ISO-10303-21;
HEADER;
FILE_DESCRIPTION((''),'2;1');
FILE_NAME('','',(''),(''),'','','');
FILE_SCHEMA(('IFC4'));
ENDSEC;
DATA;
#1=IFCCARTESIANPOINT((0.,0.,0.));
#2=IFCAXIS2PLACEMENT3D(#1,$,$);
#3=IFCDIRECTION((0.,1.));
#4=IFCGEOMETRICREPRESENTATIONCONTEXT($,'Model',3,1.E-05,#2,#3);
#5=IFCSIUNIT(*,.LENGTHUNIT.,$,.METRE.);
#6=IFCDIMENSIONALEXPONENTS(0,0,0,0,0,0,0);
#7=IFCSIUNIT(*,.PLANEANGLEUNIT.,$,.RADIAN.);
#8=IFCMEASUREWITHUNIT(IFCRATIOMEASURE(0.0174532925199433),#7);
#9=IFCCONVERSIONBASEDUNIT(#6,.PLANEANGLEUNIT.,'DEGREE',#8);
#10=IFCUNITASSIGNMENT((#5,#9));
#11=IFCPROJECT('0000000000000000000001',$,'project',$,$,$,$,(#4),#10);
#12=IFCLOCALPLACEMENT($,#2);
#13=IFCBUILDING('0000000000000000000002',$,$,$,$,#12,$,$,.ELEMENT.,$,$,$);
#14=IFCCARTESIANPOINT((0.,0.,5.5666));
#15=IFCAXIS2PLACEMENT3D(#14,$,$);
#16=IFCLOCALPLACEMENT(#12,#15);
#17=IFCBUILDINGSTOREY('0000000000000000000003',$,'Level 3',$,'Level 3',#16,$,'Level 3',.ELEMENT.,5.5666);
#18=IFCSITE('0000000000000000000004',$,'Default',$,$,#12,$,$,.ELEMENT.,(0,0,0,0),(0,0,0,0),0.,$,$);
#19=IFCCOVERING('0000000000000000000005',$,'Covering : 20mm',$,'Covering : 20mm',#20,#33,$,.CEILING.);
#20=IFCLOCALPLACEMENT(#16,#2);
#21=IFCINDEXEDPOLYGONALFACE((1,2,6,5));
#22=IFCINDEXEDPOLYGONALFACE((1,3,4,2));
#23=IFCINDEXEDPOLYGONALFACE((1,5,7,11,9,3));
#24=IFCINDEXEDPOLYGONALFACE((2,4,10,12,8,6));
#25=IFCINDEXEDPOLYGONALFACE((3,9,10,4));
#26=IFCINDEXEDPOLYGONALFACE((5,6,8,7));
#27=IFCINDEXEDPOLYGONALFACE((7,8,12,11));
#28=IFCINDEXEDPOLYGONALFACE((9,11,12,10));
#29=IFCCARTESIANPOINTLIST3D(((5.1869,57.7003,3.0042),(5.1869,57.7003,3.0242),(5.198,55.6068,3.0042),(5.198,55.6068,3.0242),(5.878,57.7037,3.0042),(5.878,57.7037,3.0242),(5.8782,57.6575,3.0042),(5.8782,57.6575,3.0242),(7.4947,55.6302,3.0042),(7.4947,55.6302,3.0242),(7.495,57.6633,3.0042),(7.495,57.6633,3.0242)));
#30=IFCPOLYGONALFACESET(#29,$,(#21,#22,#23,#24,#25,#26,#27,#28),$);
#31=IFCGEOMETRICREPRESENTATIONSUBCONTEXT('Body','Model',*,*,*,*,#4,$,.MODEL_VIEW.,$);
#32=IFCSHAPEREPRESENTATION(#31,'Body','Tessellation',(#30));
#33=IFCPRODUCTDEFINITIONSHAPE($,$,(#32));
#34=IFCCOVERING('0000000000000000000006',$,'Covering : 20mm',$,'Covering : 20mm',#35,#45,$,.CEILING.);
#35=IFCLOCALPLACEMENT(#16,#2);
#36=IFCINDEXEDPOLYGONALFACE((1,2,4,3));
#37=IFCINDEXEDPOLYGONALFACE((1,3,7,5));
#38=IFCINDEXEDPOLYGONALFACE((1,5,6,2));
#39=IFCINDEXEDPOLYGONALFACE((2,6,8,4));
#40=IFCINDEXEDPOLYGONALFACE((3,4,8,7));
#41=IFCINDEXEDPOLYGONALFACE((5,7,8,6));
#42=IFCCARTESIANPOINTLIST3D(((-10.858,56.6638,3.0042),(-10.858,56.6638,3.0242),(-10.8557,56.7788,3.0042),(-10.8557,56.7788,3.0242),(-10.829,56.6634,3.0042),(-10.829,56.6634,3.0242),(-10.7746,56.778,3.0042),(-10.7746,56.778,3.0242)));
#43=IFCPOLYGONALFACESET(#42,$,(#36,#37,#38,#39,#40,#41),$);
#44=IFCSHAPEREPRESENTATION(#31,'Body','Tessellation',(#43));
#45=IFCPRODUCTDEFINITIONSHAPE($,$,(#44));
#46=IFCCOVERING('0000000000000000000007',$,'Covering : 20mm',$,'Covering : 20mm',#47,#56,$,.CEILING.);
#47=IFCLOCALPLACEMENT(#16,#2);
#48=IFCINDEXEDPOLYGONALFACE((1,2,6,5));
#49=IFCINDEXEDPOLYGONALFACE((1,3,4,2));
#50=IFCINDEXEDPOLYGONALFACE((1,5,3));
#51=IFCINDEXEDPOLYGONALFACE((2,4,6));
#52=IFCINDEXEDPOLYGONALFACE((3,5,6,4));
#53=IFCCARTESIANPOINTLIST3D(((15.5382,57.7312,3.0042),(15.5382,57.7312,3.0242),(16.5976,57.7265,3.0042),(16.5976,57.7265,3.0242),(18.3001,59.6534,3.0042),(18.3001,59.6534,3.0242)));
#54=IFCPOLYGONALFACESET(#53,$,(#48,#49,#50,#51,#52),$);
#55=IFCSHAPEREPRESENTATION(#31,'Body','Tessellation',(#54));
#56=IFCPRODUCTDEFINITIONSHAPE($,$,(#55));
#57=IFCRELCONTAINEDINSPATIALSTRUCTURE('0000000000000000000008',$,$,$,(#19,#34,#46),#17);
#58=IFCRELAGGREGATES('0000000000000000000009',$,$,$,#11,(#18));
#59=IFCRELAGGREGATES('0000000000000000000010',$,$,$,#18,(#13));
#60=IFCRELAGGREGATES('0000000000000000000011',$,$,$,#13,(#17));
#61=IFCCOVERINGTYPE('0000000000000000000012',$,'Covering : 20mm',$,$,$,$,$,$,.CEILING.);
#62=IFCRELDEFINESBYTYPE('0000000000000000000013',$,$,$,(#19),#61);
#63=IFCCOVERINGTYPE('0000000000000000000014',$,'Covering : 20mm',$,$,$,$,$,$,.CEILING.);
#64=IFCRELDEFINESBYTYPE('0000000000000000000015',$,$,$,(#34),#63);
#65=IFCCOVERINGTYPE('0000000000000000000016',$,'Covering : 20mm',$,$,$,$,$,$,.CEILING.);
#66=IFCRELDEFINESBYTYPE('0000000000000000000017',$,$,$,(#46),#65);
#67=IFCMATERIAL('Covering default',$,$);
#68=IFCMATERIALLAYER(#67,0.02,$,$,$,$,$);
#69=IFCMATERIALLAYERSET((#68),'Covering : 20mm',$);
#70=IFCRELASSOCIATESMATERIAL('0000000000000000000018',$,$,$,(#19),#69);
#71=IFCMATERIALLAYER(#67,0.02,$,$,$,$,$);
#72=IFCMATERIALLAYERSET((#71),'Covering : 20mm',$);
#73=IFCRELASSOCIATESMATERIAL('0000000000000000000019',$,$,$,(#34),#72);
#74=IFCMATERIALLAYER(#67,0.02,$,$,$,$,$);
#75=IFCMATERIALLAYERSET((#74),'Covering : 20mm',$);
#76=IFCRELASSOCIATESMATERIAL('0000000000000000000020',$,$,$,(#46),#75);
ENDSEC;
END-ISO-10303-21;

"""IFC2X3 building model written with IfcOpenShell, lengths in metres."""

from ifc_helpers import new_model, entity, si_unit, converted_unit, direction, frame, origin, origin_with_axes, place, context, subcontext, project, spatial, polyline, outline, extrude, material, layer, layer_set, layer_usage, type_object, element, save


model = new_model("IFC2X3")

# Units and contexts
model_context = context("Model", 3, precision=1e-05, world=origin(), true_north=direction((0.0, 1.0)))
body_context = subcontext(model_context, "Body", "Model", "MODEL_VIEW")
ifc_project = project(units=[si_unit("LENGTHUNIT", "METRE"), converted_unit("PLANEANGLEUNIT", "DEGREE", entity("IfcRatioMeasure", 0.0174532925199433), si_unit("PLANEANGLEUNIT", "RADIAN"), dimensions=[0, 0, 0, 0, 0, 0, 0])], contexts=[model_context])

# Site, building, storey
placement = place(None, origin())
site = spatial("IfcSite", under=ifc_project, at=placement, Name="Default", CompositionType="ELEMENT", RefLatitude=(0, 0, 0, 0), RefLongitude=(0, 0, 0, 0), RefElevation=0.0)
building = spatial("IfcBuilding", under=site, at=placement, CompositionType="ELEMENT")
storey_placement = place(placement, frame((0.0, 0.0, 5.5666)))
storey = spatial("IfcBuildingStorey", under=building, at=storey_placement, Name="Level 3", ObjectType="Level 3", LongName="Level 3", CompositionType="ELEMENT", Elevation=5.5666)

# Coverings
ifc_material_1 = material(Name="Covering default")
ifc_layer_1 = layer(ifc_material_1, 0.02)
ifc_layer_set_1 = layer_set([ifc_layer_1], Name="Covering : 20mm")
ifc_layer_usage_1 = layer_usage(ifc_layer_set_1, "AXIS3", "POSITIVE", 0.0)
covering_type_1 = type_object("IfcCoveringType", Name="Covering : 20mm", PredefinedType="CEILING")
covering_1_placement = place(placement, frame((0.0, 0.0, 8.5708)))
element("IfcCovering", 1, at=covering_1_placement, inside=storey, type_object=covering_type_1, material=ifc_layer_usage_1, Name="Covering : 20mm", ObjectType="Covering : 20mm", PredefinedType="CEILING", context=body_context, shape_type="SweptSolid", body=[
    extrude(outline(polyline([(5.198, 55.6068), (7.4947, 55.6302), (7.495, 57.6633), (5.8782, 57.6575), (5.878, 57.7037), (5.1869, 57.7003), (5.198, 55.6068)])), origin_with_axes(), (0.0, 0.0, 1.0), 0.02),
])
ifc_layer_2 = layer(ifc_material_1, 0.02)
ifc_layer_set_2 = layer_set([ifc_layer_2], Name="Covering : 20mm")
ifc_layer_usage_2 = layer_usage(ifc_layer_set_2, "AXIS3", "POSITIVE", 0.0)
covering_type_2 = type_object("IfcCoveringType", Name="Covering : 20mm", PredefinedType="CEILING")
covering_2_placement = place(placement, frame((0.0, 0.0, 8.5708)))
element("IfcCovering", 2, at=covering_2_placement, inside=storey, type_object=covering_type_2, material=ifc_layer_usage_2, Name="Covering : 20mm", ObjectType="Covering : 20mm", PredefinedType="CEILING", context=body_context, shape_type="SweptSolid", body=[
    extrude(outline(polyline([(-10.8557, 56.7788), (-10.7746, 56.778), (-10.829, 56.6634), (-10.858, 56.6638), (-10.8557, 56.7788)])), origin_with_axes(), (0.0, 0.0, 1.0), 0.02),
])
ifc_layer_3 = layer(ifc_material_1, 0.02)
ifc_layer_set_3 = layer_set([ifc_layer_3], Name="Covering : 20mm")
ifc_layer_usage_3 = layer_usage(ifc_layer_set_3, "AXIS3", "POSITIVE", 0.0)
covering_type_3 = type_object("IfcCoveringType", Name="Covering : 20mm", PredefinedType="CEILING")
covering_3_placement = place(placement, frame((0.0, 0.0, 8.5708)))
element("IfcCovering", 3, at=covering_3_placement, inside=storey, type_object=covering_type_3, material=ifc_layer_usage_3, Name="Covering : 20mm", ObjectType="Covering : 20mm", PredefinedType="CEILING", context=body_context, shape_type="SweptSolid", body=[
    extrude(outline(polyline([(15.5382, 57.7312), (18.3001, 59.6534), (16.5976, 57.7265), (15.5382, 57.7312)])), origin_with_axes(), (0.0, 0.0, 1.0), 0.02),
])

save(model, "model.ifc")
